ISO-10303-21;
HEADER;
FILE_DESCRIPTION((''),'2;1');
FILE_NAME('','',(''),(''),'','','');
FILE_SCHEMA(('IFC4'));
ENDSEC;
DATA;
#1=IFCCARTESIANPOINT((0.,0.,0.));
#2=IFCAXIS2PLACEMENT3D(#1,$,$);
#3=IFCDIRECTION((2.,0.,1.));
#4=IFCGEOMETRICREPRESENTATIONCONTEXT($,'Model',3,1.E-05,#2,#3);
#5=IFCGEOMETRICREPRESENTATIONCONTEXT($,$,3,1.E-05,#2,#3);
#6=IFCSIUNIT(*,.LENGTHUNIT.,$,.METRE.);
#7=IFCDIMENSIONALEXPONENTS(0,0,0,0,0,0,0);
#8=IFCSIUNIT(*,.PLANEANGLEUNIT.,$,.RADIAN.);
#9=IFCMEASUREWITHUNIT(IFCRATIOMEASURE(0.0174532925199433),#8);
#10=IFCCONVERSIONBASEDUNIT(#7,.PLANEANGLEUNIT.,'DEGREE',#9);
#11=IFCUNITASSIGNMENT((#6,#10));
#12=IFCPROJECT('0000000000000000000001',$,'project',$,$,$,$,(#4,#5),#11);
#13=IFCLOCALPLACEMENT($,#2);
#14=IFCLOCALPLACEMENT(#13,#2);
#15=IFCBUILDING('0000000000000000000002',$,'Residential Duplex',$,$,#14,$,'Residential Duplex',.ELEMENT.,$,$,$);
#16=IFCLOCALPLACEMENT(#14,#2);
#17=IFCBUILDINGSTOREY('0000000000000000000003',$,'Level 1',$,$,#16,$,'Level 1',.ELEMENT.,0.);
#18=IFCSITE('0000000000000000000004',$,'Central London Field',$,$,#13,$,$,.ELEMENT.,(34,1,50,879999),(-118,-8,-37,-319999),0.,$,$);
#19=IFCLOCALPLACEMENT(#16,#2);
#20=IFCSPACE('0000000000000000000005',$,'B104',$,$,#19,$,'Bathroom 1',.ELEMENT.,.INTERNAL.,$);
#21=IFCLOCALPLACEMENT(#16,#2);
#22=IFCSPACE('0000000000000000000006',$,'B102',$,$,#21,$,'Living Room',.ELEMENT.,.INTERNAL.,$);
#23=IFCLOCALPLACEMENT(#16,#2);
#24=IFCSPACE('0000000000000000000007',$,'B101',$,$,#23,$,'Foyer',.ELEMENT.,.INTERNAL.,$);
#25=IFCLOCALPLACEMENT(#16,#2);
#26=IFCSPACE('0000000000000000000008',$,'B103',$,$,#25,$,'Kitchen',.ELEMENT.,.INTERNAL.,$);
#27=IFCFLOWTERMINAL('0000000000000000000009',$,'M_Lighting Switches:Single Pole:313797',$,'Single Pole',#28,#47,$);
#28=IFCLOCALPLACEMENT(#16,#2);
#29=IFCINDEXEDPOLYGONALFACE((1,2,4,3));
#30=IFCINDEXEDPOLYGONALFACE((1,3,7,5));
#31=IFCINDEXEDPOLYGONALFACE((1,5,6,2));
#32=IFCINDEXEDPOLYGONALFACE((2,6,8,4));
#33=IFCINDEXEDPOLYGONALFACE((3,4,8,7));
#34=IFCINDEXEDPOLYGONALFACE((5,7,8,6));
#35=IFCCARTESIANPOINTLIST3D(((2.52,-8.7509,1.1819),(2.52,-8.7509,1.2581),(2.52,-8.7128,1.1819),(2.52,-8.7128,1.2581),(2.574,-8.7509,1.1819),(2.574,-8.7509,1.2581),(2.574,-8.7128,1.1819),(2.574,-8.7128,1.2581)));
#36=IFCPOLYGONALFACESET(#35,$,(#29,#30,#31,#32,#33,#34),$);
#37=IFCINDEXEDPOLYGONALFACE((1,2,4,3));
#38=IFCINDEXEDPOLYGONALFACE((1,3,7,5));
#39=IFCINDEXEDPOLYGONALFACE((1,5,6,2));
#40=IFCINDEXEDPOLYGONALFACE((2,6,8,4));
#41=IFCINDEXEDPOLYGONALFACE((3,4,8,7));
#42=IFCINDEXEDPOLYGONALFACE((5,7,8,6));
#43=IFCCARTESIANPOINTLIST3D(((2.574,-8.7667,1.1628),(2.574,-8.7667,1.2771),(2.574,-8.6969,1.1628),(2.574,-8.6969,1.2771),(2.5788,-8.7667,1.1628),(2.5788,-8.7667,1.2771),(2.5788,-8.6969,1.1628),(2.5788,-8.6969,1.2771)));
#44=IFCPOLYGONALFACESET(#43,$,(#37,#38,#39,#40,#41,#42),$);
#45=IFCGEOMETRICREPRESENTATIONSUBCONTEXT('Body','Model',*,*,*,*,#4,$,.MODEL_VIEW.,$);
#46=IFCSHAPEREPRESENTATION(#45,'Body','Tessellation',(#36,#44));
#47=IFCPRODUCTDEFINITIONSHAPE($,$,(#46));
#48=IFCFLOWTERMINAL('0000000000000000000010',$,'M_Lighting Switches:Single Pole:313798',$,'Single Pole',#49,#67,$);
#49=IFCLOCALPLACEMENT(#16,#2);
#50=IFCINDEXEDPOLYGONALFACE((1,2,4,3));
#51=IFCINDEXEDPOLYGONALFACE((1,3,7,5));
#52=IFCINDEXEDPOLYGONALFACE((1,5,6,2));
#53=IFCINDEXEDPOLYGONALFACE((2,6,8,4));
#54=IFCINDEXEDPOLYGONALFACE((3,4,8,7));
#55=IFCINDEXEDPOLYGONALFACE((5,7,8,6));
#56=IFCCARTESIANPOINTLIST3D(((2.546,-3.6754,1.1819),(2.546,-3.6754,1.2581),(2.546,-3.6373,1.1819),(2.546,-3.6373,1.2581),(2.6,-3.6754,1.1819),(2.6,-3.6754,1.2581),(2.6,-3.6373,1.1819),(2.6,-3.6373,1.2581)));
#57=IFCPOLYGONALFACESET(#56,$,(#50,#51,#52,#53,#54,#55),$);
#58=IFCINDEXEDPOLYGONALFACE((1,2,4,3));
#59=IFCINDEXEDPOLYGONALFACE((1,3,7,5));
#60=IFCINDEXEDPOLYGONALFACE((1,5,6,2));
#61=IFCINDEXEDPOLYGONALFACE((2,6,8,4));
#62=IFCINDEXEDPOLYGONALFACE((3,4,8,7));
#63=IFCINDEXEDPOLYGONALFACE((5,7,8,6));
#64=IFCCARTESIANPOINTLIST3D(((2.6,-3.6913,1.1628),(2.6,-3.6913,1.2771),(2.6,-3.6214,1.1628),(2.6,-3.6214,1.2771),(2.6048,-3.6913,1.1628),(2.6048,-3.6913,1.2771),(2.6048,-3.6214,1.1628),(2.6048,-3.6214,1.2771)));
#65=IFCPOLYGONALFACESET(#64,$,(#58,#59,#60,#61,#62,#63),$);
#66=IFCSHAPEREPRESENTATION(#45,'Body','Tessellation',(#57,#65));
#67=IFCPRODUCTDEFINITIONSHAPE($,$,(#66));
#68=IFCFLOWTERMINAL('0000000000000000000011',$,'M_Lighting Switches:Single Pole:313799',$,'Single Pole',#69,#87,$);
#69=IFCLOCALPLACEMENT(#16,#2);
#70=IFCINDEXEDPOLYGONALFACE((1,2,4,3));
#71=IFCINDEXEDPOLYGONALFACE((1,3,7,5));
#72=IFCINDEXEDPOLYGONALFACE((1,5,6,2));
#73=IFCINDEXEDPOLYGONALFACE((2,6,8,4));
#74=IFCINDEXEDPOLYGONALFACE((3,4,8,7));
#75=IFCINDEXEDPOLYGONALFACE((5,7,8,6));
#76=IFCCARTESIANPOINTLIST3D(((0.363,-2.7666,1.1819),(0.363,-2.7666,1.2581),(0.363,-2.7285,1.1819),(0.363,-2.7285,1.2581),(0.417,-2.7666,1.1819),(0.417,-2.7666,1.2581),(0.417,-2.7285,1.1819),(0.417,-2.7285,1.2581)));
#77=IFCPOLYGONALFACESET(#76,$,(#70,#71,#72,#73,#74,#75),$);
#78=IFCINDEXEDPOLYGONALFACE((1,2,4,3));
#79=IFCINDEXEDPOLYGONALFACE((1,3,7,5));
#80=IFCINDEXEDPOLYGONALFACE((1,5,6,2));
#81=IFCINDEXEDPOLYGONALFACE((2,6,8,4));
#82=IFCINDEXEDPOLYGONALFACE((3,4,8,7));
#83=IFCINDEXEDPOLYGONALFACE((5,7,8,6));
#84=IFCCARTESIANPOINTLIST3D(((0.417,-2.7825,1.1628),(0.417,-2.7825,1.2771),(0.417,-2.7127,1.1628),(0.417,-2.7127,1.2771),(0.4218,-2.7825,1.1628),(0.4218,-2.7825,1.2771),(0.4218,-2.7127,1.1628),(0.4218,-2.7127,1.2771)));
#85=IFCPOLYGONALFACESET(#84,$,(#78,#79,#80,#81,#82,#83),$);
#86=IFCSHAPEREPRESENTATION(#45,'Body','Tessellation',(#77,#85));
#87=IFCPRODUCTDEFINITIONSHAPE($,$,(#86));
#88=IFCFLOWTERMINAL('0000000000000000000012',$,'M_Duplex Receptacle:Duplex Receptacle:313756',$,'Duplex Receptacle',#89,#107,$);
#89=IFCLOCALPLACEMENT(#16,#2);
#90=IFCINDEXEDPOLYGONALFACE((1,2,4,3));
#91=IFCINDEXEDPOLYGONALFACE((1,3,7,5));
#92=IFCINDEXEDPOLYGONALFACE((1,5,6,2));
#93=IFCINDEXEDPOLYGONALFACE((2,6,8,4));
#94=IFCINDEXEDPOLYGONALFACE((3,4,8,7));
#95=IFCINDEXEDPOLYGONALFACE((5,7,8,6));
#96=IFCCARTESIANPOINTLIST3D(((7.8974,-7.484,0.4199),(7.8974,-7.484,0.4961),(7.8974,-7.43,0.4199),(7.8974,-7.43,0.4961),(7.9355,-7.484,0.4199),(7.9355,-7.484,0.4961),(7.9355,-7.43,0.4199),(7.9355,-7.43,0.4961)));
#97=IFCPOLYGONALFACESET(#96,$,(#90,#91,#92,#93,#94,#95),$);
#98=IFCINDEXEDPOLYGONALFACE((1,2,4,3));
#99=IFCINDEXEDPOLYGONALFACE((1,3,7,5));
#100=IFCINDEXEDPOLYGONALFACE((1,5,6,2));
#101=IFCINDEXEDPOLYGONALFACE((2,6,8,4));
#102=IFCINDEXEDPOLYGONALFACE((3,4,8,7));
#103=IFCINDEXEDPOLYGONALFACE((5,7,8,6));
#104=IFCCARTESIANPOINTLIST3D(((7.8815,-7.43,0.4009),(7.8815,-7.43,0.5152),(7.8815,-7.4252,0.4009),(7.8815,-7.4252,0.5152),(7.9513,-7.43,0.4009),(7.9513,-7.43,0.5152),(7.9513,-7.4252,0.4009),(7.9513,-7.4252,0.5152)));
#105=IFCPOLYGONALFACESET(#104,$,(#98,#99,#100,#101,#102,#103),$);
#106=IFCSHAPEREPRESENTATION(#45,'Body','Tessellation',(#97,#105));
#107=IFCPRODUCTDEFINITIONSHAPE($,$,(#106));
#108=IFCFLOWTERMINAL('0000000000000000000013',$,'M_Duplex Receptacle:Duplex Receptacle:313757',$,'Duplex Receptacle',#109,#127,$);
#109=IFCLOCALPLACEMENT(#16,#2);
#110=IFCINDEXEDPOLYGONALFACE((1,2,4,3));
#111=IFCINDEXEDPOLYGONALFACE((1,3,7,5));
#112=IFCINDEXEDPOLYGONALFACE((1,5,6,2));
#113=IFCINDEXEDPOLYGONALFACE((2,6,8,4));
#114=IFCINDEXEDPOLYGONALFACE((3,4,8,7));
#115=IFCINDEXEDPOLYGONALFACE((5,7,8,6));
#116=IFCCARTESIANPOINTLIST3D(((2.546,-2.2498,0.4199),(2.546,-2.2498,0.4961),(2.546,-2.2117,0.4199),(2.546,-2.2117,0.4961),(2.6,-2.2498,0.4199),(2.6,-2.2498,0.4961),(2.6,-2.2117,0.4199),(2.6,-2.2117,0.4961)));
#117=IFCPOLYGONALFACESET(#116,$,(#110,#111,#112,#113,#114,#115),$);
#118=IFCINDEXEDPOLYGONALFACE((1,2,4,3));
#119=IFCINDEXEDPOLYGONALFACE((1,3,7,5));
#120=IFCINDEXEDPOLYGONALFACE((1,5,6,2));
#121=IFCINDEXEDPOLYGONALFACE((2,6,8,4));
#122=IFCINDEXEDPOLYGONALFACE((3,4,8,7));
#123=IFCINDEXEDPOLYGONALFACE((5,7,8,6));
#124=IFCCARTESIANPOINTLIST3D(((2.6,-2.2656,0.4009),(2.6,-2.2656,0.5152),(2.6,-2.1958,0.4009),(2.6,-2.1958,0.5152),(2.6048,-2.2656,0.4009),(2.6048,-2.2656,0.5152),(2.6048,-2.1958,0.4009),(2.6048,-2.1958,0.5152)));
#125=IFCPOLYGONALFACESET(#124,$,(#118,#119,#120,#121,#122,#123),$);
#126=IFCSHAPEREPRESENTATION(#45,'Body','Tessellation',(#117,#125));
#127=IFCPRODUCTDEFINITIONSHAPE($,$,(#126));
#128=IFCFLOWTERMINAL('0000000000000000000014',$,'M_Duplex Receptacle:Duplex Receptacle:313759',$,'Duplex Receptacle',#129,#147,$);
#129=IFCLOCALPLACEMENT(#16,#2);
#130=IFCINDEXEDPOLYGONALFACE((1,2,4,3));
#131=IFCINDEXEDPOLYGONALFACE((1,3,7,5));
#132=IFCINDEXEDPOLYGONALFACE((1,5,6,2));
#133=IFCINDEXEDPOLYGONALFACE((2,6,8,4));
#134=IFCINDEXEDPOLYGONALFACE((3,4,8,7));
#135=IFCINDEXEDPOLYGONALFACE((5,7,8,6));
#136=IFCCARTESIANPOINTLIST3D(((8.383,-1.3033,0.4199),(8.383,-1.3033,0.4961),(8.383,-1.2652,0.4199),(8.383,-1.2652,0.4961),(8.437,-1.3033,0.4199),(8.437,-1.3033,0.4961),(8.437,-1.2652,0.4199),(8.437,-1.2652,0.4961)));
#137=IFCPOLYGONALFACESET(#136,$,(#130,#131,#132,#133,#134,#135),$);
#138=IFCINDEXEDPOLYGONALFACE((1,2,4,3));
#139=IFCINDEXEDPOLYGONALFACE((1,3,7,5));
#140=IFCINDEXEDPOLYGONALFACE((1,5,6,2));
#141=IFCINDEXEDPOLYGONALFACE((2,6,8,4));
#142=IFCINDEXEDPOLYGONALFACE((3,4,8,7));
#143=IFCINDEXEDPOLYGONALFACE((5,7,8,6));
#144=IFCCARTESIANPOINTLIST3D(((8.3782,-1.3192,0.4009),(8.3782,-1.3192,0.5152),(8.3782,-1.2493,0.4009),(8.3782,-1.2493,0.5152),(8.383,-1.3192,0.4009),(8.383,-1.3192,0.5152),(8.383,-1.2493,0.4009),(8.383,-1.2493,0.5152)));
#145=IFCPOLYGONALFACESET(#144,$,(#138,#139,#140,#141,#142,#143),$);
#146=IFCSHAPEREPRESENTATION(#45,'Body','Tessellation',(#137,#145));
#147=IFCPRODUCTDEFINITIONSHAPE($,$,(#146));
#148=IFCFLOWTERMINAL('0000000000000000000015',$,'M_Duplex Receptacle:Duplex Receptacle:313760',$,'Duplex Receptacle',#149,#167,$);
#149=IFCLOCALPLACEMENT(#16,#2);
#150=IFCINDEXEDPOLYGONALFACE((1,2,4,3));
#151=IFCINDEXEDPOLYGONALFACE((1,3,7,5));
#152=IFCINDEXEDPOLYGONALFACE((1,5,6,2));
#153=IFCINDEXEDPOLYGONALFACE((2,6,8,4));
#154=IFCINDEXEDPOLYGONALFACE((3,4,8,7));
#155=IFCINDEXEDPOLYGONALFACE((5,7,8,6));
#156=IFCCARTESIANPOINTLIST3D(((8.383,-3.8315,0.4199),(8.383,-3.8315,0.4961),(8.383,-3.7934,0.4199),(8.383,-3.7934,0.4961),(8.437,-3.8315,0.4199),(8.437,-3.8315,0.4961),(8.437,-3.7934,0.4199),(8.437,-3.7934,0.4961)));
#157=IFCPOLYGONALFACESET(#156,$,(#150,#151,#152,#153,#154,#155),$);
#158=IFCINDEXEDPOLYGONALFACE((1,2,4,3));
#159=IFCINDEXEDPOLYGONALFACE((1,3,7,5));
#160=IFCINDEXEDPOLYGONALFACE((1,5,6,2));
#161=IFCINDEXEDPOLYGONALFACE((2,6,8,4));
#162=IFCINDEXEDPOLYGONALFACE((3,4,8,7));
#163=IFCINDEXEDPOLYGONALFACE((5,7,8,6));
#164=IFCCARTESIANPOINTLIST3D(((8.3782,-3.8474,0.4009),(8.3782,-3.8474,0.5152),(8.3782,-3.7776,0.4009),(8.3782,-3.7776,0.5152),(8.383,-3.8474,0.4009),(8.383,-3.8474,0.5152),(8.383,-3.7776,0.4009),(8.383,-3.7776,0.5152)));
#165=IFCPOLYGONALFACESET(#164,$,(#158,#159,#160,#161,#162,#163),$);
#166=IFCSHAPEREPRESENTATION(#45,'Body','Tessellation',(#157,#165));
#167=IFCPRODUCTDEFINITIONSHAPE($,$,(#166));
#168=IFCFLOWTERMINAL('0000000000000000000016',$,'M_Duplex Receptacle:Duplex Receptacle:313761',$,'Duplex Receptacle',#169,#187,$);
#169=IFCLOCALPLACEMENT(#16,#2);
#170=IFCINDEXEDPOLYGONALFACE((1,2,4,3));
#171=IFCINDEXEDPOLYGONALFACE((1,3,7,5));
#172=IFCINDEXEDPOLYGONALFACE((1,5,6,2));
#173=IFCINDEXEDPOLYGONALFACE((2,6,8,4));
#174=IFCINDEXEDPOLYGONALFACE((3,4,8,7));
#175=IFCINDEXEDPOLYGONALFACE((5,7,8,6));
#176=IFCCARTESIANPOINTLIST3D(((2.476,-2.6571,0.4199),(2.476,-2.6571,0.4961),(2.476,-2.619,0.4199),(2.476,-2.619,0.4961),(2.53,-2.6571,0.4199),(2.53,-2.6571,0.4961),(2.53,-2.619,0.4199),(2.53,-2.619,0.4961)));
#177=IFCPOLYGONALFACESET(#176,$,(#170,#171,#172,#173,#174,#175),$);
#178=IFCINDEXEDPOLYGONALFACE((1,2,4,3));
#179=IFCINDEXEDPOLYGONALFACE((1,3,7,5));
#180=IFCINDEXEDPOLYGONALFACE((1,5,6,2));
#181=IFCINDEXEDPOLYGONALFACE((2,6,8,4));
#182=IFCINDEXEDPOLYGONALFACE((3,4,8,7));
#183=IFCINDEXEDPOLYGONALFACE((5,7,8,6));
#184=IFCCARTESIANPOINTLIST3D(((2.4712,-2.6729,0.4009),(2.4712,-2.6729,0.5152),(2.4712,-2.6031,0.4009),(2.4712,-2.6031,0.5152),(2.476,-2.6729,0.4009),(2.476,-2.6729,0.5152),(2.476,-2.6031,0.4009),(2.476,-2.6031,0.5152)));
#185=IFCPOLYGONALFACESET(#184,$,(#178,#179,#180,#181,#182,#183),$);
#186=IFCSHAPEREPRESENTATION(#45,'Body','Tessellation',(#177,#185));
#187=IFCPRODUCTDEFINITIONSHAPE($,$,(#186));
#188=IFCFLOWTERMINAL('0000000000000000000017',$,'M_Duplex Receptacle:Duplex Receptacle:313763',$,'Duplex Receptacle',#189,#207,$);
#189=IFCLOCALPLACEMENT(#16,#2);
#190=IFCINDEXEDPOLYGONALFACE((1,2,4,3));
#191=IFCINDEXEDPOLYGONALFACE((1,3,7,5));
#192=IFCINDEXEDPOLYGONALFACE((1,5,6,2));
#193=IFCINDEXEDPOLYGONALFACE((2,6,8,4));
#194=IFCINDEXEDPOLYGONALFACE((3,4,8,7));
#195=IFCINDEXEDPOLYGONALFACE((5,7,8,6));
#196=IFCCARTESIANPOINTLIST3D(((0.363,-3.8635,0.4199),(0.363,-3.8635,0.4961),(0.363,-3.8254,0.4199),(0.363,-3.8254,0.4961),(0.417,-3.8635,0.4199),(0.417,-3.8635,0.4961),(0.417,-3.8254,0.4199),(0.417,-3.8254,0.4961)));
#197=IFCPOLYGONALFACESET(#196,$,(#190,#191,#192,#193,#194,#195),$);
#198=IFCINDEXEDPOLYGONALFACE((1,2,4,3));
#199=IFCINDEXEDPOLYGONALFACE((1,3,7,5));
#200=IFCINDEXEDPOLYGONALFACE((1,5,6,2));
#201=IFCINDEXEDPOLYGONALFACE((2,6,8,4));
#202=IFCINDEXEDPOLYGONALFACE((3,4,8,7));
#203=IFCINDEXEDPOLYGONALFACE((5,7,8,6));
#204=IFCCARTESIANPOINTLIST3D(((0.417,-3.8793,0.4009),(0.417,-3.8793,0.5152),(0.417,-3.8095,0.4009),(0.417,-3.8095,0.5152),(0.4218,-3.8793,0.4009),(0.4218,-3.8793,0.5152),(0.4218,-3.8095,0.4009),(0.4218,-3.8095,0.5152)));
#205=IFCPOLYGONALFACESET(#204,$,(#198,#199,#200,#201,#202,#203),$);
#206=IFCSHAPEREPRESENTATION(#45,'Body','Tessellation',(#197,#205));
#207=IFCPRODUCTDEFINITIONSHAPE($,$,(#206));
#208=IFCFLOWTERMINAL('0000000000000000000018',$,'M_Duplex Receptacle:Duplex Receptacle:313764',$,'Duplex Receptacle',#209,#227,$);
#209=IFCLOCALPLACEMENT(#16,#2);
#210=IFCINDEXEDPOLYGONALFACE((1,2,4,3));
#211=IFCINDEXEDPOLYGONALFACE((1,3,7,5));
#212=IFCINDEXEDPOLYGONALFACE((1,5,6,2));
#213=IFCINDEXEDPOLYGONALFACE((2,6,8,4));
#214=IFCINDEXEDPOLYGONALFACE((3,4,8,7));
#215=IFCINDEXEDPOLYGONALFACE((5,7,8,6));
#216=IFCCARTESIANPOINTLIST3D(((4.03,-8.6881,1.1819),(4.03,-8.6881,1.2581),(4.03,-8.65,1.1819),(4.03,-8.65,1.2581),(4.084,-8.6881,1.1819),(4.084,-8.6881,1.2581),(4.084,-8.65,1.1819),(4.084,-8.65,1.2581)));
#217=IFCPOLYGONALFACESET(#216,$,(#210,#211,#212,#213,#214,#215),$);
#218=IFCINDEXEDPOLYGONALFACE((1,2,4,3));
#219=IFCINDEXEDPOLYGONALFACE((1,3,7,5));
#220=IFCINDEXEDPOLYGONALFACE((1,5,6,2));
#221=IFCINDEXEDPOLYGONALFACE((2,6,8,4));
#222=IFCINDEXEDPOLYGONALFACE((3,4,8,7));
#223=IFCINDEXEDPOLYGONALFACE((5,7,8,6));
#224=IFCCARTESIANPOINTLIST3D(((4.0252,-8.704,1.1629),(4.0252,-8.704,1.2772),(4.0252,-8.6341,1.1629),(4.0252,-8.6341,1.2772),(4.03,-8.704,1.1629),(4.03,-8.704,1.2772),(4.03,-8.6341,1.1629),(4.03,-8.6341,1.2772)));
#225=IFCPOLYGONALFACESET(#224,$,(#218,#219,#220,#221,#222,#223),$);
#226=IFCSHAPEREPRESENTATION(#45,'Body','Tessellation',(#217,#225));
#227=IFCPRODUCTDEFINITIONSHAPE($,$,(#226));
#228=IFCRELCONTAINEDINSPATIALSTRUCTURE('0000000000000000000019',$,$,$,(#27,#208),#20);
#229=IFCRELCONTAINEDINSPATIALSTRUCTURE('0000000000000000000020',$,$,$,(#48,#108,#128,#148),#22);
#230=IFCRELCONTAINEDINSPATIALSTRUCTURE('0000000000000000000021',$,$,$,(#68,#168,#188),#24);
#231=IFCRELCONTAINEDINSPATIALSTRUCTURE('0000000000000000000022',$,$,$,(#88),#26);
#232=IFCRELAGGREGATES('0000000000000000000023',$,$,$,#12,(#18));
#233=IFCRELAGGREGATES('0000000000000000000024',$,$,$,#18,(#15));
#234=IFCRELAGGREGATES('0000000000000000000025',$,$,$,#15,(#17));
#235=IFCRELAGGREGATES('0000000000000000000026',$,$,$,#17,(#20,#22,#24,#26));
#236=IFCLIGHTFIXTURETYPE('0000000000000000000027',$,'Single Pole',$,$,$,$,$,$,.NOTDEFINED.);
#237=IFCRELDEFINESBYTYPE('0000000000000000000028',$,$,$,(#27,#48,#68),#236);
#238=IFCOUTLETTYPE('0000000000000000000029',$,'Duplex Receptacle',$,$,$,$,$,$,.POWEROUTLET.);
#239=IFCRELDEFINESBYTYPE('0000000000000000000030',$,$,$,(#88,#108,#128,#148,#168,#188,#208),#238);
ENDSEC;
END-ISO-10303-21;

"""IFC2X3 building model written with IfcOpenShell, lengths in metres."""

from ifc_helpers import new_model, entity, si_unit, converted_unit, direction, frame, frame_2d, origin, origin_2d_with_axis, place, context, subcontext, project, spatial, rectangle, extrude, source, transform, mapped, type_object, type_shapes, element, save


model = new_model("IFC2X3")

# Units and contexts
model_context = context("Model", 3, precision=1e-05, world=origin(), true_north=direction((2.0, 0.0, 1.0)))
context_of_model = context(None, 3, precision=1e-05, world=origin(), true_north=direction((2.0, 0.0, 1.0)))
body_context = subcontext(model_context, "Body", "Model", "MODEL_VIEW")
ifc_project = project(units=[si_unit("LENGTHUNIT", "METRE"), converted_unit("PLANEANGLEUNIT", "DEGREE", entity("IfcRatioMeasure", 0.0174532925199433), si_unit("PLANEANGLEUNIT", "RADIAN"), dimensions=[0, 0, 0, 0, 0, 0, 0])], contexts=[model_context, context_of_model])

# Site, building, storey, space
site_placement = place(None, origin())
site = spatial("IfcSite", under=ifc_project, at=site_placement, Name="Central London Field", CompositionType="ELEMENT", RefLatitude=(34, 1, 50, 879999), RefLongitude=(-118, -8, -37, -319999), RefElevation=0.0)
building_placement = place(site_placement, origin())
building = spatial("IfcBuilding", under=site, at=building_placement, Name="Residential Duplex", LongName="Residential Duplex", CompositionType="ELEMENT")
storey_placement = place(building_placement, origin())
storey = spatial("IfcBuildingStorey", under=building, at=storey_placement, Name="Level 1", LongName="Level 1", CompositionType="ELEMENT", Elevation=0.0)
space_1_placement = place(storey_placement, origin())
space_1 = spatial("IfcSpace", under=storey, at=space_1_placement, Name="B104", LongName="Bathroom 1", CompositionType="ELEMENT", InteriorOrExteriorSpace="INTERNAL")

# Flow terminal
light_fixture_type = type_object("IfcLightFixtureType", Name="Single Pole", PredefinedType="NOTDEFINED")
shared_shape_1 = source(origin(), body_context, "Body", "SweptSolid", [
    extrude(rectangle(XDim=0.0381, YDim=0.0762, at=origin_2d_with_axis()), frame((0.0, 0.0, -0.054), z_axis=(0.0, 0.0, 1.0), x_axis=(-1.0, 0.0, 0.0)), (0.0, 0.0, 1.0), 0.054),
    extrude(rectangle(XDim=0.0698, YDim=0.1143, at=frame_2d((0.0, 0.0), x_axis=(1.0, 0.0))), frame((0.0, 0.0, 0.0), z_axis=(0.0, 0.0, 1.0), x_axis=(-1.0, 0.0, 0.0)), (0.0, 0.0, 1.0), 0.0048),
])
type_shapes(light_fixture_type, [shared_shape_1])
flow_terminal_1_placement = place(space_1_placement, frame((2.574, -8.7318, 1.22), z_axis=(1.0, 0.0, 0.0), x_axis=(0.0, 1.0, 0.0)))
element("IfcFlowTerminal", 1, at=flow_terminal_1_placement, inside=space_1, type_object=light_fixture_type, Name="M_Lighting Switches:Single Pole:313797", ObjectType="Single Pole", context=body_context, shape_type="MappedRepresentation", body=[
    mapped(shared_shape_1, transform((0.0, 0.0, 0.0), scale=1.0)),
])

# Shared definitions
space_2_placement = place(storey_placement, origin())
space_2 = spatial("IfcSpace", under=storey, at=space_2_placement, Name="B102", LongName="Living Room", CompositionType="ELEMENT", InteriorOrExteriorSpace="INTERNAL")

# Flow terminal
flow_terminal_2_placement = place(space_2_placement, frame((2.6, -3.6564, 1.22), z_axis=(1.0, 0.0, 0.0), x_axis=(0.0, 1.0, 0.0)))
element("IfcFlowTerminal", 2, at=flow_terminal_2_placement, inside=space_2, type_object=light_fixture_type, Name="M_Lighting Switches:Single Pole:313798", ObjectType="Single Pole", context=body_context, shape_type="MappedRepresentation", body=[
    mapped(shared_shape_1, transform((0.0, 0.0, 0.0), scale=1.0)),
])

# Shared definitions
space_3_placement = place(storey_placement, origin())
space_3 = spatial("IfcSpace", under=storey, at=space_3_placement, Name="B101", LongName="Foyer", CompositionType="ELEMENT", InteriorOrExteriorSpace="INTERNAL")

# Flow terminal
flow_terminal_3_placement = place(space_3_placement, frame((0.417, -2.7476, 1.22), z_axis=(1.0, 0.0, 0.0), x_axis=(0.0, 1.0, 0.0)))
element("IfcFlowTerminal", 3, at=flow_terminal_3_placement, inside=space_3, type_object=light_fixture_type, Name="M_Lighting Switches:Single Pole:313799", ObjectType="Single Pole", context=body_context, shape_type="MappedRepresentation", body=[
    mapped(shared_shape_1, transform((0.0, 0.0, 0.0), scale=1.0)),
])

# Shared definitions
space_4_placement = place(storey_placement, origin())
space_4 = spatial("IfcSpace", under=storey, at=space_4_placement, Name="B103", LongName="Kitchen", CompositionType="ELEMENT", InteriorOrExteriorSpace="INTERNAL")

# Flow terminals
outlet_type = type_object("IfcOutletType", Name="Duplex Receptacle", PredefinedType="POWEROUTLET")
shared_shape_2 = source(origin(), body_context, "Body", "SweptSolid", [
    extrude(rectangle(XDim=0.0381, YDim=0.0762, at=origin_2d_with_axis()), frame((0.0, 0.0, -0.054), z_axis=(0.0, 0.0, 1.0), x_axis=(-1.0, 0.0, 0.0)), (0.0, 0.0, 1.0), 0.054),
    extrude(rectangle(XDim=0.0698, YDim=0.1143, at=frame_2d((0.0, 0.0), x_axis=(1.0, 0.0))), frame((0.0, 0.0, 0.0), z_axis=(0.0, 0.0, 1.0), x_axis=(-1.0, 0.0, 0.0)), (0.0, 0.0, 1.0), 0.0048),
])
type_shapes(outlet_type, [shared_shape_2])
flow_terminal_4_placement = place(space_4_placement, frame((7.9164, -7.43, 0.458), z_axis=(0.0, 1.0, 0.0), x_axis=(-1.0, 0.0, 0.0)))
element("IfcFlowTerminal", 4, at=flow_terminal_4_placement, inside=space_4, type_object=outlet_type, Name="M_Duplex Receptacle:Duplex Receptacle:313756", ObjectType="Duplex Receptacle", context=body_context, shape_type="MappedRepresentation", body=[
    mapped(shared_shape_2, transform((0.0, 0.0, 0.0), scale=1.0)),
])
for number, where, z_axis, x_axis, name in (
    (5, (2.6, -2.2307, 0.458), (1.0, 0.0, 0.0), (0.0, 1.0, 0.0), "M_Duplex Receptacle:Duplex Receptacle:313757"),
    (6, (8.383, -1.2842, 0.458), (-1.0, 0.0, 0.0), (0.0, -1.0, 0.0), "M_Duplex Receptacle:Duplex Receptacle:313759"),
    (7, (8.383, -3.8125, 0.458), (-1.0, 0.0, 0.0), (0.0, -1.0, 0.0), "M_Duplex Receptacle:Duplex Receptacle:313760"),
):
    element("IfcFlowTerminal", number, at=place(space_2_placement, frame(where, z_axis=z_axis, x_axis=x_axis)), inside=space_2, type_object=outlet_type, Name=name, ObjectType="Duplex Receptacle", context=body_context, shape_type="MappedRepresentation", body=[
        mapped(shared_shape_2, transform((0.0, 0.0, 0.0), scale=1.0)),
    ])
for number, where, z_axis, x_axis, name in (
    (8, (2.476, -2.638, 0.458), (-1.0, 0.0, 0.0), (0.0, -1.0, 0.0), "M_Duplex Receptacle:Duplex Receptacle:313761"),
    (9, (0.417, -3.8444, 0.458), (1.0, 0.0, 0.0), (0.0, 1.0, 0.0), "M_Duplex Receptacle:Duplex Receptacle:313763"),
):
    element("IfcFlowTerminal", number, at=place(space_3_placement, frame(where, z_axis=z_axis, x_axis=x_axis)), inside=space_3, type_object=outlet_type, Name=name, ObjectType="Duplex Receptacle", context=body_context, shape_type="MappedRepresentation", body=[
        mapped(shared_shape_2, transform((0.0, 0.0, 0.0), scale=1.0)),
    ])
flow_terminal_5_placement = place(space_1_placement, frame((4.03, -8.6691, 1.22), z_axis=(-1.0, 0.0, 0.0), x_axis=(0.0, -1.0, 0.0)))
element("IfcFlowTerminal", 10, at=flow_terminal_5_placement, inside=space_1, type_object=outlet_type, Name="M_Duplex Receptacle:Duplex Receptacle:313764", ObjectType="Duplex Receptacle", context=body_context, shape_type="MappedRepresentation", body=[
    mapped(shared_shape_2, transform((0.0, 0.0, 0.0), scale=1.0)),
])

save(model, "model.ifc")
